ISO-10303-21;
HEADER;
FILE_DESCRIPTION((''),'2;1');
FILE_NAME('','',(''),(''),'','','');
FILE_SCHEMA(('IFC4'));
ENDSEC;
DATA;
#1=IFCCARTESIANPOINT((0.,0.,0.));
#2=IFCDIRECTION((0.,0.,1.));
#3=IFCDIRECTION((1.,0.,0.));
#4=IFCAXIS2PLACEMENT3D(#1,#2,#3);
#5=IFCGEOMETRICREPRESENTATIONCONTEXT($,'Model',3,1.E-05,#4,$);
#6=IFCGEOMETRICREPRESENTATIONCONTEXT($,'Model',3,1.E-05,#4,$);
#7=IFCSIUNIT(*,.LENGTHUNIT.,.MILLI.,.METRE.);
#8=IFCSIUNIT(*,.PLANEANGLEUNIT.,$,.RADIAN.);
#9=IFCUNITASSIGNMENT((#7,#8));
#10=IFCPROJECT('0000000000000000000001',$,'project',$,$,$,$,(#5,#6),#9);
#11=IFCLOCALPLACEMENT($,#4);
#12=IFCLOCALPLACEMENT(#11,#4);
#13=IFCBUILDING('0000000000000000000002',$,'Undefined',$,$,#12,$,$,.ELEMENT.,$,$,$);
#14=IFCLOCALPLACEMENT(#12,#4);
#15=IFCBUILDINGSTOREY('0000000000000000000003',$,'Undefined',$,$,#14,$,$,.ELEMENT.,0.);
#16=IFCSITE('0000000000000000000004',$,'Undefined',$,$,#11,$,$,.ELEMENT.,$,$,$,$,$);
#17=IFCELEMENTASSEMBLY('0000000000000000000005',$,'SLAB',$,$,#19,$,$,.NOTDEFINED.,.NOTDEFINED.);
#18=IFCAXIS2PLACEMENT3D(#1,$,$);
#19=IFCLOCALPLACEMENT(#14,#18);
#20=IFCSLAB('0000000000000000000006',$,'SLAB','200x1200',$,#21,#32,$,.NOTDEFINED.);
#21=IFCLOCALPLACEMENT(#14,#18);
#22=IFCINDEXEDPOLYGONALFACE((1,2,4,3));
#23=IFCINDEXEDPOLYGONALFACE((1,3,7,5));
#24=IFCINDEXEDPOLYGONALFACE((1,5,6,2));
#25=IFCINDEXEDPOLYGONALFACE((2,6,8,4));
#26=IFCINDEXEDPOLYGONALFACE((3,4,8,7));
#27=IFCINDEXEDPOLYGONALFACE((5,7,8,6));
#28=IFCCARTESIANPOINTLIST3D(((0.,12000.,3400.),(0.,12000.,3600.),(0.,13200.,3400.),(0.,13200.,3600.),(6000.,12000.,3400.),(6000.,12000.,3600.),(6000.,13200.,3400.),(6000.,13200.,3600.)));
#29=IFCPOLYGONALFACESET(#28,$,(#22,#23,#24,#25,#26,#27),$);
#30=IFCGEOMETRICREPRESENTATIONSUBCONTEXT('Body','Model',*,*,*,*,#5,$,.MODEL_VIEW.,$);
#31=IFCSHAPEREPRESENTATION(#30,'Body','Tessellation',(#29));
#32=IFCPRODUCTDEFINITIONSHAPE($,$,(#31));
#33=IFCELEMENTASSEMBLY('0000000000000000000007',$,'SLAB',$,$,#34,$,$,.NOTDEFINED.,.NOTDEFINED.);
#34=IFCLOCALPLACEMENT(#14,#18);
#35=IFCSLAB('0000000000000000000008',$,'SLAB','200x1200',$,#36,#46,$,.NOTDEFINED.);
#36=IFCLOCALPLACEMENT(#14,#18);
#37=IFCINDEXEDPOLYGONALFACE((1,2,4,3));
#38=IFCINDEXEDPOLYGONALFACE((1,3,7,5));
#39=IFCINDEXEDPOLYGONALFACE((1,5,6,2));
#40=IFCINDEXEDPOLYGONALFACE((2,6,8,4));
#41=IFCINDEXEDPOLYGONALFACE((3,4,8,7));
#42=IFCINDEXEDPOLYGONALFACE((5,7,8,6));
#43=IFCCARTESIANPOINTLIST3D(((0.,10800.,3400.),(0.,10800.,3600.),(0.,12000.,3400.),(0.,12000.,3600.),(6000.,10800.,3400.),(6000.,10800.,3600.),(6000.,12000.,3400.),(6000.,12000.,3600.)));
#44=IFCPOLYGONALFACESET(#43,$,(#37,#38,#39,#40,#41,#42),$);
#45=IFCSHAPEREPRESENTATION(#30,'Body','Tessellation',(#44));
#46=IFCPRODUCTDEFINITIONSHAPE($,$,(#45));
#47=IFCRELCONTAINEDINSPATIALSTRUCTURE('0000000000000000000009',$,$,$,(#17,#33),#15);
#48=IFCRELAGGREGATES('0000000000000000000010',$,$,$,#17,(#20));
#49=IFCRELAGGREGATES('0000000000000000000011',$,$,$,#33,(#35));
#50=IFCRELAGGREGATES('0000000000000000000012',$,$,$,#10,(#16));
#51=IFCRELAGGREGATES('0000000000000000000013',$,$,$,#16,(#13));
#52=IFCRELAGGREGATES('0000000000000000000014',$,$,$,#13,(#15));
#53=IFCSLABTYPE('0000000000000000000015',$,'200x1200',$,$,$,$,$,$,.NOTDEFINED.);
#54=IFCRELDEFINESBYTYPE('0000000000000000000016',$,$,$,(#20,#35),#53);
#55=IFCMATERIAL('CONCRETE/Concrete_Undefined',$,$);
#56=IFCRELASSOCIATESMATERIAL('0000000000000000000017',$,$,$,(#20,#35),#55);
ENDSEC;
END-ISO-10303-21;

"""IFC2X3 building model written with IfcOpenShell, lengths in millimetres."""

from ifc_helpers import new_model, si_unit, frame, origin_with_axes, place, context, subcontext, project, spatial, polyline, outline, extrude, material, type_object, element, aggregate, save


model = new_model("IFC2X3")

# Units and contexts
model_context_1 = context("Model", 3, precision=1e-05, world=origin_with_axes())
model_context_2 = context("Model", 3, precision=1e-05, world=origin_with_axes())
body_context = subcontext(model_context_1, "Body", "Model", "MODEL_VIEW")
ifc_project = project(units=[si_unit("LENGTHUNIT", "METRE", prefix="MILLI"), si_unit("PLANEANGLEUNIT", "RADIAN")], contexts=[model_context_1, model_context_2])

# Site, building, storey
site_placement = place(None, origin_with_axes())
site = spatial("IfcSite", under=ifc_project, at=site_placement, Name="Undefined", CompositionType="ELEMENT")
building_placement = place(site_placement, origin_with_axes())
building = spatial("IfcBuilding", under=site, at=building_placement, Name="Undefined", CompositionType="ELEMENT")
storey_placement = place(building_placement, origin_with_axes())
storey = spatial("IfcBuildingStorey", under=building, at=storey_placement, Name="Undefined", CompositionType="ELEMENT", Elevation=0.0)

# Shared definitions
ifc_material_1 = material(Name="CONCRETE/Concrete_Undefined")

# Element assemblies, slabs
assembly_1_placement = place(storey_placement, origin_with_axes())
assembly_1 = element("IfcElementAssembly", 1, at=assembly_1_placement, inside=storey, Name="SLAB", AssemblyPlace="NOTDEFINED", PredefinedType="NOTDEFINED")
slab_type = type_object("IfcSlabType", Name="200x1200", PredefinedType="NOTDEFINED")
slab_1_placement = place(assembly_1_placement, frame((6000.0, 12000.0, 3500.0), z_axis=(0.0, 0.0, 1.0), x_axis=(0.0, 1.0, 0.0)))
slab_1 = element("IfcSlab", 2, at=slab_1_placement, type_object=slab_type, material=ifc_material_1, Name="SLAB", Description="200x1200", PredefinedType="NOTDEFINED", context=body_context, shape_type="SweptSolid", body=[
    extrude(outline(polyline([(0.0, 0.0), (1200.0, 0.0), (1200.0, 6000.0), (0.0, 6000.0), (0.0, 0.0)])), frame((0.0, 0.0, -100.0), z_axis=(0.0, 0.0, 1.0), x_axis=(1.0, 0.0, 0.0)), (0.0, 0.0, 1.0), 200.0),
])
aggregate(assembly_1, [slab_1])
assembly_2_placement = place(storey_placement, origin_with_axes())
assembly_2 = element("IfcElementAssembly", 3, at=assembly_2_placement, inside=storey, Name="SLAB", AssemblyPlace="NOTDEFINED", PredefinedType="NOTDEFINED")
slab_2_placement = place(assembly_2_placement, frame((6000.0, 10800.0, 3500.0), z_axis=(0.0, 0.0, 1.0), x_axis=(0.0, 1.0, 0.0)))
slab_2 = element("IfcSlab", 4, at=slab_2_placement, type_object=slab_type, material=ifc_material_1, Name="SLAB", Description="200x1200", PredefinedType="NOTDEFINED", context=body_context, shape_type="SweptSolid", body=[
    extrude(outline(polyline([(0.0, 0.0), (1200.0, 0.0), (1200.0, 6000.0), (0.0, 6000.0), (0.0, 0.0)])), frame((0.0, 0.0, -100.0), z_axis=(0.0, 0.0, 1.0), x_axis=(1.0, 0.0, 0.0)), (0.0, 0.0, 1.0), 200.0),
])
aggregate(assembly_2, [slab_2])

save(model, "model.ifc")
